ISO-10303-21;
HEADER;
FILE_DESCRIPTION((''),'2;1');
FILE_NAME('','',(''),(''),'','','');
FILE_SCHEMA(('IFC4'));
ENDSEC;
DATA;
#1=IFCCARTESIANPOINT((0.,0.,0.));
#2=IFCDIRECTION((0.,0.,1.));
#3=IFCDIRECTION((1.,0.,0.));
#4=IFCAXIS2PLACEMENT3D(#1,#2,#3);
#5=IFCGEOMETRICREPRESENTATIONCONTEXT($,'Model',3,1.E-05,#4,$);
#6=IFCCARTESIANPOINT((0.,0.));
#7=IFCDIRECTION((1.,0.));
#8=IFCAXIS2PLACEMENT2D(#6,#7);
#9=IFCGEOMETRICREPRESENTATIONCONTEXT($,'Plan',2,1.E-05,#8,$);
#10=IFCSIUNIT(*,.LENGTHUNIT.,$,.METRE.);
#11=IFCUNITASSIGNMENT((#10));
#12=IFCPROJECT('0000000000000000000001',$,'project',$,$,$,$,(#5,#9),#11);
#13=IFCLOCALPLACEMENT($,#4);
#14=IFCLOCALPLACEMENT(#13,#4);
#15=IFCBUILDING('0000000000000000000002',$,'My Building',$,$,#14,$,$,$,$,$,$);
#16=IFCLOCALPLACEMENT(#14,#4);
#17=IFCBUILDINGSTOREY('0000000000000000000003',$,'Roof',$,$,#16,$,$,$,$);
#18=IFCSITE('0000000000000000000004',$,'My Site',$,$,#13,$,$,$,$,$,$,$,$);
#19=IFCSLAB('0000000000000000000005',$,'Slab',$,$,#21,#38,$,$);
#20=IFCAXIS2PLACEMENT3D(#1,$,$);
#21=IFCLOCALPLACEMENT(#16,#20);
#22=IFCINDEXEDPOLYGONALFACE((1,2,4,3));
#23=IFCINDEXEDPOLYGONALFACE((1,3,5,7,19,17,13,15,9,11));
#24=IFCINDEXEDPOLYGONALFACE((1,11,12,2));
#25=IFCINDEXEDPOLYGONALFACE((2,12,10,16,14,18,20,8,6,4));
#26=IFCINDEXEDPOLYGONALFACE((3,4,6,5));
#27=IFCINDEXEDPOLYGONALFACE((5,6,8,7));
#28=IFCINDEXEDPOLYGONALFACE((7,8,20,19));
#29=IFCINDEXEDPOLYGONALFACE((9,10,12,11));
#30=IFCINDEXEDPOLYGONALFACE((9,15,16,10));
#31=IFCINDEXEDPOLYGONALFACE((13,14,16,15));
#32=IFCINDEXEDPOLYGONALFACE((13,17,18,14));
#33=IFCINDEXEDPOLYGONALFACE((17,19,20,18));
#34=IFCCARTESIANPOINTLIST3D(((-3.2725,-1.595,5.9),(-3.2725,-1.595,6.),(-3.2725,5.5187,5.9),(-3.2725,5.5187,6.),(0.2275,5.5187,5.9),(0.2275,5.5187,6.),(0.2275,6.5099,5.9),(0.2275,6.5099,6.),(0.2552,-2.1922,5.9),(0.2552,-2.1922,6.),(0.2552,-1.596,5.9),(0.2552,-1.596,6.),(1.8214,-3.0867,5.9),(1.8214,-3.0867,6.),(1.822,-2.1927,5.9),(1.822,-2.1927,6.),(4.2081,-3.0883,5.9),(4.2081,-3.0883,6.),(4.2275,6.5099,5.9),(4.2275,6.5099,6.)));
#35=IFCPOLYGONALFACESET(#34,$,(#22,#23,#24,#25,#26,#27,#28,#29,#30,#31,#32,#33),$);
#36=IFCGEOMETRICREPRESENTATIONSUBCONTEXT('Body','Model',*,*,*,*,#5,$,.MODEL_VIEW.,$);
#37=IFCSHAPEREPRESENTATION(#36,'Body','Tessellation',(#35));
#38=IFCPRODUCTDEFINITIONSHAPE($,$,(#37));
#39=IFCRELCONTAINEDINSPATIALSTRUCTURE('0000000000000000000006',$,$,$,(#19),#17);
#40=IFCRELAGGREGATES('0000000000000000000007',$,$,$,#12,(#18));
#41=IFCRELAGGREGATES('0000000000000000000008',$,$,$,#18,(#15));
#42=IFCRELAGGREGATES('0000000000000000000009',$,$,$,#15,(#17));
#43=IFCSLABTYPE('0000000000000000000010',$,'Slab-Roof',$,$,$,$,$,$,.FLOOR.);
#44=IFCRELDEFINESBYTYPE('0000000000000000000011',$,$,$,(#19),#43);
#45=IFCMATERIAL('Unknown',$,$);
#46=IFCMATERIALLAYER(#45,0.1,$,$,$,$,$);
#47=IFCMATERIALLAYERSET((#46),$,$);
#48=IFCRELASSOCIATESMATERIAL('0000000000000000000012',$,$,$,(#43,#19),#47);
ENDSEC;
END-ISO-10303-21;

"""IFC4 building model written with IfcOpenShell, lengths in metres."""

from ifc_helpers import new_model, si_unit, frame, origin_with_axes, origin_2d_with_axis, place, context, subcontext, project, spatial, indexed_curve, outline, extrude, material, layer, layer_set, layer_usage, type_object, element, save


model = new_model("IFC4")

# Units and contexts
model_context = context("Model", 3, precision=1e-05, world=origin_with_axes())
plan_context = context("Plan", 2, precision=1e-05, world=origin_2d_with_axis())
body_context = subcontext(model_context, "Body", "Model", "MODEL_VIEW")
ifc_project = project(units=[si_unit("LENGTHUNIT", "METRE")], contexts=[model_context, plan_context])

# Site, building, storey
site_placement = place(None, origin_with_axes())
site = spatial("IfcSite", under=ifc_project, at=site_placement, Name="My Site")
building_placement = place(site_placement, origin_with_axes())
building = spatial("IfcBuilding", under=site, at=building_placement, Name="My Building")
storey_placement = place(building_placement, origin_with_axes())
storey = spatial("IfcBuildingStorey", under=building, at=storey_placement, Name="Roof")

# Slab
ifc_material = material(Name="Unknown")
ifc_layer = layer(ifc_material, 0.1)
ifc_layer_set = layer_set([ifc_layer])
ifc_layer_usage = layer_usage(ifc_layer_set, "AXIS3", "POSITIVE", -0.1)
slab_type = type_object("IfcSlabType", Name="Slab-Roof", PredefinedType="FLOOR", material=ifc_layer_set)
slab_placement = place(storey_placement, frame((4.2275, 6.5099, 6.0), z_axis=(0.0, 0.0, 1.0), x_axis=(1.0, 0.0, 0.0)))
element("IfcSlab", 1, at=slab_placement, inside=storey, type_object=slab_type, material=ifc_layer_usage, Name="Slab", context=body_context, shape_type="SweptSolid", body=[
    extrude(outline(indexed_curve([(0.0, 0.0), (-4.0, 0.0), (-4.0, -0.9913), (-7.5, -0.9913), (-7.5, -8.1049), (-3.9723, -8.1059), (-3.9723, -8.7022), (-2.4055, -8.7026), (-2.4061, -9.5967), (-0.0194, -9.5982), (0.0, 0.0)])), frame((0.0, 0.0, -0.1), z_axis=(0.0, 0.0, 1.0), x_axis=(1.0, 0.0, 0.0)), (0.0, 0.0, 1.0), 0.1),
])

save(model, "model.ifc")
